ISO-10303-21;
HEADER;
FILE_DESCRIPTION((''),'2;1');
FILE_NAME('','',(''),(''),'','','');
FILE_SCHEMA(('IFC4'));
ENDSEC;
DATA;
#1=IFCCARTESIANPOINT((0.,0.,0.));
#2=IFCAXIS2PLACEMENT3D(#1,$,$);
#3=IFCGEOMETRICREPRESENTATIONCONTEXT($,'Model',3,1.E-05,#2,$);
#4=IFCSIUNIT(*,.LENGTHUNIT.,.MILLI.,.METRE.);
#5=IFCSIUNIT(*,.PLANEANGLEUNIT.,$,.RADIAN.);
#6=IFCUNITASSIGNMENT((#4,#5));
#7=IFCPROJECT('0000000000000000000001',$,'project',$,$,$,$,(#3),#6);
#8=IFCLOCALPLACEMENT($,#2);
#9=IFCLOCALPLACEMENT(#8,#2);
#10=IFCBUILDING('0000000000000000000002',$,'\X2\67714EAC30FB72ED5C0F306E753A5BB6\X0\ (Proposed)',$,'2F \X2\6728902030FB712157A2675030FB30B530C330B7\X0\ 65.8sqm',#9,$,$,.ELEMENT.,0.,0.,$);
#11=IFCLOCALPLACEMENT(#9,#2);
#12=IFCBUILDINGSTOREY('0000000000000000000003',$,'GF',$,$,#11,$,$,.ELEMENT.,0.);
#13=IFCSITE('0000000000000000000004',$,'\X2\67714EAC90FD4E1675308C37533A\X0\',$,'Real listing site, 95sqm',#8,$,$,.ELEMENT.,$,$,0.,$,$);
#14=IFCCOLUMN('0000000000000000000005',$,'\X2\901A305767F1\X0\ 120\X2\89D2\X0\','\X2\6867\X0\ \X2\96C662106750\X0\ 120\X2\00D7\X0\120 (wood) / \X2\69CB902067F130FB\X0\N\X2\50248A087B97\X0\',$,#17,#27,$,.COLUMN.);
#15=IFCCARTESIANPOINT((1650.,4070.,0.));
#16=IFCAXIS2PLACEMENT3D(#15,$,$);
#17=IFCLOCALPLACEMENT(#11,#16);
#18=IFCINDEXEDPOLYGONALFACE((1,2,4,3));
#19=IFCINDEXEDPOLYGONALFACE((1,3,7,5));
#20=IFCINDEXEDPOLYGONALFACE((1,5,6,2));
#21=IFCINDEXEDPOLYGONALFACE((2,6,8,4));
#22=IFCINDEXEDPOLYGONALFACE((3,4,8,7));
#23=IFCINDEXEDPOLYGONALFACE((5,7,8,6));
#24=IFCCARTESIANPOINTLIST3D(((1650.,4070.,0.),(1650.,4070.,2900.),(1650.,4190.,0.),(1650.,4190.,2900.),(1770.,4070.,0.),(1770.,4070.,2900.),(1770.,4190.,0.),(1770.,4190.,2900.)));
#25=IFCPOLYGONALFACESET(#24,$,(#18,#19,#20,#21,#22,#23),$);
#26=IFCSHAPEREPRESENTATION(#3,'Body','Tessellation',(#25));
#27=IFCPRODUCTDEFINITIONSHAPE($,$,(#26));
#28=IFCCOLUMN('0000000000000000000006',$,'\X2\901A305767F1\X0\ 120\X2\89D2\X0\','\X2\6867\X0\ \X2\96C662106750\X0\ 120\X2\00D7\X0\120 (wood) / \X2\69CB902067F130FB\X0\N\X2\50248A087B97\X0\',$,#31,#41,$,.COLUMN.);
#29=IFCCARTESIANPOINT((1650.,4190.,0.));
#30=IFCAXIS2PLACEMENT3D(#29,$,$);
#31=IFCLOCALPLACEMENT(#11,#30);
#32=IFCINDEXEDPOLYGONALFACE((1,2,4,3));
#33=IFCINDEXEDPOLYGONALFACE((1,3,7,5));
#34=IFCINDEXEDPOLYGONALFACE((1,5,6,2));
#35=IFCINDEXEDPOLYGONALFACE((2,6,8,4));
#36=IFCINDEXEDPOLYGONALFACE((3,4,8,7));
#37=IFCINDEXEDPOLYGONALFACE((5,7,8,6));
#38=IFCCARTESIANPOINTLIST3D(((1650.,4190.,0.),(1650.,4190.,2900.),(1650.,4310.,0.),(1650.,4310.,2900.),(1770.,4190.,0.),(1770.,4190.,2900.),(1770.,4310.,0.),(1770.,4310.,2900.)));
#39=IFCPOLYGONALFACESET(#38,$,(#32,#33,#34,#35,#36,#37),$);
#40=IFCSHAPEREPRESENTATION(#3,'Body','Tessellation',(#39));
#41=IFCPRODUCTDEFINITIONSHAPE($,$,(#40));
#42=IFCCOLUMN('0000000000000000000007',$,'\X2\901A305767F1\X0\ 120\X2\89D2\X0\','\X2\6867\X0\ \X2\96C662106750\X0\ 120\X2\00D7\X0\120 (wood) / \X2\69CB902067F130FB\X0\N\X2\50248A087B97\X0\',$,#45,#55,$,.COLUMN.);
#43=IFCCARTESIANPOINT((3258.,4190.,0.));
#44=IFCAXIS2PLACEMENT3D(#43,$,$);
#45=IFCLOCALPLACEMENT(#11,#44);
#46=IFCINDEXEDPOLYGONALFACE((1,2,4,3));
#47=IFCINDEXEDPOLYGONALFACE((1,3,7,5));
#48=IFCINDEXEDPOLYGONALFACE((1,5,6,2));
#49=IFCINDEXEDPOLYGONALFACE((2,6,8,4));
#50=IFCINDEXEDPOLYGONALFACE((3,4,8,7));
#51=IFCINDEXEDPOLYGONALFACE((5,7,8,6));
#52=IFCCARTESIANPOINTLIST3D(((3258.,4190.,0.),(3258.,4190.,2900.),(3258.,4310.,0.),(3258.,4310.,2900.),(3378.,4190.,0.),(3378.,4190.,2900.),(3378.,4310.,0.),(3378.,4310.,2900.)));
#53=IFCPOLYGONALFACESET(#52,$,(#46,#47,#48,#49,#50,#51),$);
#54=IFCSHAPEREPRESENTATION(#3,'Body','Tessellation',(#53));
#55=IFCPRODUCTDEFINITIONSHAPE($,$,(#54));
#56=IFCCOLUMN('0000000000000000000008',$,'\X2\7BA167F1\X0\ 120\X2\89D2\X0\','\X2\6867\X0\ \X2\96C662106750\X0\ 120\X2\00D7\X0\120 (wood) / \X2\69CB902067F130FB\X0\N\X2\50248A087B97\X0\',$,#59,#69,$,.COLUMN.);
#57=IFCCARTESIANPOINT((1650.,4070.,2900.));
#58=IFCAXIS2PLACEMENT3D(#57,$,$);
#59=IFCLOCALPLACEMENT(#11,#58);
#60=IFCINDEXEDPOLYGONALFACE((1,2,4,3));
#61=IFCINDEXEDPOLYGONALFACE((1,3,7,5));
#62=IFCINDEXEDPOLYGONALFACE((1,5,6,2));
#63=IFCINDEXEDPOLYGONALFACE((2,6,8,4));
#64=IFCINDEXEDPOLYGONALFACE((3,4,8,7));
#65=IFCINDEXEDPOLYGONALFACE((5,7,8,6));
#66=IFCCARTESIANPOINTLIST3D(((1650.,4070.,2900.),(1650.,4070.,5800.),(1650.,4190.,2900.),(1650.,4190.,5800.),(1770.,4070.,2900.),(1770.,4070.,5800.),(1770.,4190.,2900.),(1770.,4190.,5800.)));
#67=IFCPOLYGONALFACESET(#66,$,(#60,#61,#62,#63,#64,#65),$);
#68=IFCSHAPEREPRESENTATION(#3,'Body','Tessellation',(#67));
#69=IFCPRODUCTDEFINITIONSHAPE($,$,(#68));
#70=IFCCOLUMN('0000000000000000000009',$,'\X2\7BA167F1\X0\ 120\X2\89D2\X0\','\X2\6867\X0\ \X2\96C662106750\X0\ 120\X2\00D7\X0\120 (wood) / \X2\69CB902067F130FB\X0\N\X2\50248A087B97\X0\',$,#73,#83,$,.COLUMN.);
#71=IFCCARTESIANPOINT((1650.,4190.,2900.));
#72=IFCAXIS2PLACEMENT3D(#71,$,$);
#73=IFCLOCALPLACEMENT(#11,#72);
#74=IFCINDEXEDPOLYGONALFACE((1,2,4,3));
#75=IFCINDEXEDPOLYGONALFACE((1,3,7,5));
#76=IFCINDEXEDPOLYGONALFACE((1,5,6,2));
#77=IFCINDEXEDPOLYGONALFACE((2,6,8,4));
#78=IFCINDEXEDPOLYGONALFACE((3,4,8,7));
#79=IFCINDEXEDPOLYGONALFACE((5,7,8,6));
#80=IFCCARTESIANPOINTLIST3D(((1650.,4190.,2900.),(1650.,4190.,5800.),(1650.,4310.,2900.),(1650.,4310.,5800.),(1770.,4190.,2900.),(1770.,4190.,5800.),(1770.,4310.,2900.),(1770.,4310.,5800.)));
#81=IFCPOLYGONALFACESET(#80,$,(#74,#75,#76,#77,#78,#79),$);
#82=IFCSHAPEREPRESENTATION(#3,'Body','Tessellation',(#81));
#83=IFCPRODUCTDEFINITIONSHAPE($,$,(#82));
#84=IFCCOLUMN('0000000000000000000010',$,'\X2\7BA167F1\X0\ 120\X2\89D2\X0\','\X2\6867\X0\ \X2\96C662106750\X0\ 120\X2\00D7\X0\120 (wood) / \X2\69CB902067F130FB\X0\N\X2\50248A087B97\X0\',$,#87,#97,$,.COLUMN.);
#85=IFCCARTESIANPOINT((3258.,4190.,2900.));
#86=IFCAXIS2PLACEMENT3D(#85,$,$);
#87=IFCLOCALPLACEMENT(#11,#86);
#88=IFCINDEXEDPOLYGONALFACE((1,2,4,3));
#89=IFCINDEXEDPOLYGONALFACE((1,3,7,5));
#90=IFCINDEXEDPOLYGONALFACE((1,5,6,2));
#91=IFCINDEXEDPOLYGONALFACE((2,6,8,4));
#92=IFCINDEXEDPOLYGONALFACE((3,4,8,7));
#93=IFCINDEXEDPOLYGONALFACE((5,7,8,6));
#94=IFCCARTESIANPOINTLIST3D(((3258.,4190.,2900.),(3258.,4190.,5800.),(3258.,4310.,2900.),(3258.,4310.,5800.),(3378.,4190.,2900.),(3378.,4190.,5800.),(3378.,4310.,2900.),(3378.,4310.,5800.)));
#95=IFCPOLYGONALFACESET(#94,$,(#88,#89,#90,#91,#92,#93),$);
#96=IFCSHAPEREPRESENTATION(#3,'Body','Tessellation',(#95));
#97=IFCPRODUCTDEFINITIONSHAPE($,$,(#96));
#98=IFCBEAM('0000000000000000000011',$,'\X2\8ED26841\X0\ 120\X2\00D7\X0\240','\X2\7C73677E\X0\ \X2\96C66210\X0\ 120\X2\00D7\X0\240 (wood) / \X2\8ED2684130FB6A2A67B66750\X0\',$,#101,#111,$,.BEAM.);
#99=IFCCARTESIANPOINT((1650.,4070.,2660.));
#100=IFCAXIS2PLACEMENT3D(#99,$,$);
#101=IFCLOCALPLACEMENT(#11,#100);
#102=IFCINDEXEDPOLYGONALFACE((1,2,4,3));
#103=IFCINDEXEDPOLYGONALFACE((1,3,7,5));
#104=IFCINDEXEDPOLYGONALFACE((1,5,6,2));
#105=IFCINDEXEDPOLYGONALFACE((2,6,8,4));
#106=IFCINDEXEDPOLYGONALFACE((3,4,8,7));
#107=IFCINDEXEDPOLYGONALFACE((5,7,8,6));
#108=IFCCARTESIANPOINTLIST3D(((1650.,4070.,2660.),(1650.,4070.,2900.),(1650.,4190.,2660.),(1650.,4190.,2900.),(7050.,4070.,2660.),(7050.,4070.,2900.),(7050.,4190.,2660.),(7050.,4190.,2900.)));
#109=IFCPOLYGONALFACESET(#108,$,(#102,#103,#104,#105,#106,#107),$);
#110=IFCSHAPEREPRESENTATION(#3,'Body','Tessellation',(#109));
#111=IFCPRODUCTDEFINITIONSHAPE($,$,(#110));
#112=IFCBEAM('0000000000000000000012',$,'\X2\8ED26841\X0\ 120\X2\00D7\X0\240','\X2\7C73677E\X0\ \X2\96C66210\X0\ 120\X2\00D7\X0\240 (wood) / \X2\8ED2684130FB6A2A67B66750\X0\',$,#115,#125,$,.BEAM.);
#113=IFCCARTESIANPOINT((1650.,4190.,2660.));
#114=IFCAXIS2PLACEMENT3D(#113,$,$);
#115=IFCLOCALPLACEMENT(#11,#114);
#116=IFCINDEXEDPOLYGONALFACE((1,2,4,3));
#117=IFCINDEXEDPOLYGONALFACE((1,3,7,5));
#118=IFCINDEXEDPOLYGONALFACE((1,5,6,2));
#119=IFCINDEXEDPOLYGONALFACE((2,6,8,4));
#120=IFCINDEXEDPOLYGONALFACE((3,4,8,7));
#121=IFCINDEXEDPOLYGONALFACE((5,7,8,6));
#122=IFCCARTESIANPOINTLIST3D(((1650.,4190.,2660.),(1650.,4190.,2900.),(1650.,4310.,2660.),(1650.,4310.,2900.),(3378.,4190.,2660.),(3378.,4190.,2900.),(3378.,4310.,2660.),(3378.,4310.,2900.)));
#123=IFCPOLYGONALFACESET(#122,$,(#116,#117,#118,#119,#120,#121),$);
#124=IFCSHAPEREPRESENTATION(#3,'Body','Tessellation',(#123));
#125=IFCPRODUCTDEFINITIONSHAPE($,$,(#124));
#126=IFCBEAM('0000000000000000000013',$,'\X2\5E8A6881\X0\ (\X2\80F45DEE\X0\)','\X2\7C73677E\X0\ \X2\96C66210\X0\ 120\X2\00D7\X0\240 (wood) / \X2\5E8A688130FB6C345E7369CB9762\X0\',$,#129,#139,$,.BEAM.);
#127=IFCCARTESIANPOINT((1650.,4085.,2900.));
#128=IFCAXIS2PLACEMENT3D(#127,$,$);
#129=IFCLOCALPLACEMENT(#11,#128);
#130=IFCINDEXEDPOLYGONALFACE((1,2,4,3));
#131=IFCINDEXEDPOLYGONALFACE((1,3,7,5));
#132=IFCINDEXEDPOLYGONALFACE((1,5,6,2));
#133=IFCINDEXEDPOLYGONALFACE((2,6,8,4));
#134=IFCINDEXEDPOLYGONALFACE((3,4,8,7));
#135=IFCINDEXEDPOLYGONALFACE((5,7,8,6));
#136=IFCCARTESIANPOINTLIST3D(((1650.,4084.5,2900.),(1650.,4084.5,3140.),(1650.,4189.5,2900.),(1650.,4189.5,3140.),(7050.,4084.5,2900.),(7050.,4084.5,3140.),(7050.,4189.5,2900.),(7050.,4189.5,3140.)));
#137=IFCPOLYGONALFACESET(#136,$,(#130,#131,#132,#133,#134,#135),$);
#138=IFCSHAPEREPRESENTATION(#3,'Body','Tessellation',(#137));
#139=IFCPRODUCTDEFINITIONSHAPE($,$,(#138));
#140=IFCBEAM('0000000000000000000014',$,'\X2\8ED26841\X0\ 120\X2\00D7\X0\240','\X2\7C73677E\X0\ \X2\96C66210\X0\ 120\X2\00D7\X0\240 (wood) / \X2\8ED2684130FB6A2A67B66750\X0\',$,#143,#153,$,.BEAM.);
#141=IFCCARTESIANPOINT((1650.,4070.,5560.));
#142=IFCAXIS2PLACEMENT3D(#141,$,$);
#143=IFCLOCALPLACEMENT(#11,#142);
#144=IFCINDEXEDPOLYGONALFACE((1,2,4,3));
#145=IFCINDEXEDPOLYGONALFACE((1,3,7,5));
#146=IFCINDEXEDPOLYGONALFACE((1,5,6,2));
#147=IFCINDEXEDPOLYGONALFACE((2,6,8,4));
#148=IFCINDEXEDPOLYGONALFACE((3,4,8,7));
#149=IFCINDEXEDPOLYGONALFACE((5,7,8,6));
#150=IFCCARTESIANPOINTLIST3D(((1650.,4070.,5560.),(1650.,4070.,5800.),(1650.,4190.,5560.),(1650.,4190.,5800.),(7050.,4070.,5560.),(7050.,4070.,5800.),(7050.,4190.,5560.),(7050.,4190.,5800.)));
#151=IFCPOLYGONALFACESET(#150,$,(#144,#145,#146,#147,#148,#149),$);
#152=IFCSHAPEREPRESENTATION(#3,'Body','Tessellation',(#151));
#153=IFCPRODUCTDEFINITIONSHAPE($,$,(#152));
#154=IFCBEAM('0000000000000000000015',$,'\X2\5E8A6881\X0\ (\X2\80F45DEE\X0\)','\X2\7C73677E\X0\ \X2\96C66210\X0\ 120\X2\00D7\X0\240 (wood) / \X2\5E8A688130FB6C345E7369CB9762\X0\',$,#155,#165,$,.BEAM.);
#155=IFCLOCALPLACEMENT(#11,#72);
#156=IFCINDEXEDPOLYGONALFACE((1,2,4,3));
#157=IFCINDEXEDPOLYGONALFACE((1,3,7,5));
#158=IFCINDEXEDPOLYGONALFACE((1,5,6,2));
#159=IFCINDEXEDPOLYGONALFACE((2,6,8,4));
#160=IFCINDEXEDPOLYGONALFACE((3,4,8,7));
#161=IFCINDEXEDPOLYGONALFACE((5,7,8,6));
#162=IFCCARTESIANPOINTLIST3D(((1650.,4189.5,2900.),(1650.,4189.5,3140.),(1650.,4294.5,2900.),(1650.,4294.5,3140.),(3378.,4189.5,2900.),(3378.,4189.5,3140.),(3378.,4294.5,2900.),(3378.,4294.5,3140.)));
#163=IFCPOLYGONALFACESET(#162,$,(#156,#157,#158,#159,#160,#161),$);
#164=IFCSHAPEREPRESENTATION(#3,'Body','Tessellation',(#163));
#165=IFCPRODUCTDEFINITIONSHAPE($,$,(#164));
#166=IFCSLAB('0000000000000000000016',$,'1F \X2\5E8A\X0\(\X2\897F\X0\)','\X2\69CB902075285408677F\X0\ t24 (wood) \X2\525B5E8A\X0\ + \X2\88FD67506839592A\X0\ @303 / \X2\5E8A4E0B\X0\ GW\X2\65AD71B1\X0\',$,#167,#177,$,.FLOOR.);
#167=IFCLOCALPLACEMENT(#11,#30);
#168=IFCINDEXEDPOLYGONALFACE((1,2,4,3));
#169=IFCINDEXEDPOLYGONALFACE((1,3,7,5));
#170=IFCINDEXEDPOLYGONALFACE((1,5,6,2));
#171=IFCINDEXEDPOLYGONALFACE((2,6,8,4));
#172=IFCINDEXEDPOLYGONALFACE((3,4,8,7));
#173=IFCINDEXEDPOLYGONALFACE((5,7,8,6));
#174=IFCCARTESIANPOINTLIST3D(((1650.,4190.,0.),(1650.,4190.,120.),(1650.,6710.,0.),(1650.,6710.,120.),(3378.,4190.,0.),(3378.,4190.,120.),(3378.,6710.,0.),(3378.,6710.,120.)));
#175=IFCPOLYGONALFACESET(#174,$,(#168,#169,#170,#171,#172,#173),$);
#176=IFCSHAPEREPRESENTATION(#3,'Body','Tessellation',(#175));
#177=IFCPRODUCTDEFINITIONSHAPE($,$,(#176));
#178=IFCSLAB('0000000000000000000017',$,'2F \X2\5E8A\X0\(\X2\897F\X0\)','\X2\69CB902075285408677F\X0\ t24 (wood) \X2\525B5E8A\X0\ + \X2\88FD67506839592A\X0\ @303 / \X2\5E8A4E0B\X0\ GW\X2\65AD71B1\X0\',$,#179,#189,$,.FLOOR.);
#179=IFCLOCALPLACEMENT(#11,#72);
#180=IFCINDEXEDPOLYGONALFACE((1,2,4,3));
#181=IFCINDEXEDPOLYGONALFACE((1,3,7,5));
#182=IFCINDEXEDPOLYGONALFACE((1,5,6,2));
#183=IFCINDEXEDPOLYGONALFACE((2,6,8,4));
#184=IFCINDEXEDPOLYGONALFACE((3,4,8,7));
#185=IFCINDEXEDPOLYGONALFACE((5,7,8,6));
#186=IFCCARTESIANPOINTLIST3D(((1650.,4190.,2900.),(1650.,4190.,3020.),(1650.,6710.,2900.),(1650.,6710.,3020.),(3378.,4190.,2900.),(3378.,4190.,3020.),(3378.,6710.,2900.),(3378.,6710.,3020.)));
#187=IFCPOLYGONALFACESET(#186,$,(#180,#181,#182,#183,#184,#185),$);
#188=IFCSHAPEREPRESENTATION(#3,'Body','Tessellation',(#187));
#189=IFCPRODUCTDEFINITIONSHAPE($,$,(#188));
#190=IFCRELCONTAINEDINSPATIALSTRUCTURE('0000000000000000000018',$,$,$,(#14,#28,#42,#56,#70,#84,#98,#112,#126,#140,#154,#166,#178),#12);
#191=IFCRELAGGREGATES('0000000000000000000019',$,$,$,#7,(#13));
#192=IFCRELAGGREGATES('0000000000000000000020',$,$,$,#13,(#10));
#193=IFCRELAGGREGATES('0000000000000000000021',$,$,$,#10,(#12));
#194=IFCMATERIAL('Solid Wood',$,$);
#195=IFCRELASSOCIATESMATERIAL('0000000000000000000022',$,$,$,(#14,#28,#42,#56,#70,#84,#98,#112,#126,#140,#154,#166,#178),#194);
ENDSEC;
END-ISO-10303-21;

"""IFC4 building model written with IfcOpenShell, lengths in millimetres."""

from ifc_helpers import new_model, si_unit, frame, frame_2d, origin, place, context, project, spatial, rectangle, extrude, material, element, save


model = new_model("IFC4")

# Units and contexts
model_context = context("Model", 3, precision=1e-05, world=origin())
ifc_project = project(units=[si_unit("LENGTHUNIT", "METRE", prefix="MILLI"), si_unit("PLANEANGLEUNIT", "RADIAN")], contexts=[model_context])

# Site, building, storey
site_placement = place(None, origin())
site = spatial("IfcSite", under=ifc_project, at=site_placement, Name="東京都世田谷区", ObjectType="Real listing site, 95sqm", CompositionType="ELEMENT", RefElevation=0.0)
building_placement = place(site_placement, origin())
building = spatial("IfcBuilding", under=site, at=building_placement, Name="東京・狭小の町家 (Proposed)", ObjectType="2F 木造・無垢材・サッシ 65.8sqm", CompositionType="ELEMENT", ElevationOfRefHeight=0.0, ElevationOfTerrain=0.0)
storey_placement = place(building_placement, origin())
storey = spatial("IfcBuildingStorey", under=building, at=storey_placement, Name="GF", CompositionType="ELEMENT", Elevation=0.0)

# Columns
ifc_material_1 = material(Name="Solid Wood")
column_1_placement = place(storey_placement, frame((1650.0, 4070.0, 0.0)))
element("IfcColumn", 1, at=column_1_placement, inside=storey, material=ifc_material_1, Name="通し柱 120角", Description="桧 集成材 120×120 (wood) / 構造柱・N値計算", PredefinedType="COLUMN", context=model_context, shape_type="SweptSolid", body=[
    extrude(rectangle(XDim=120.0, YDim=120.0, at=frame_2d((60.0, 60.0))), frame((1650.0, 4070.0, 0.0)), (0.0, 0.0, 1.0), 2900.0),
])
column_2_placement = place(storey_placement, frame((1650.0, 4190.0, 0.0)))
element("IfcColumn", 2, at=column_2_placement, inside=storey, material=ifc_material_1, Name="通し柱 120角", Description="桧 集成材 120×120 (wood) / 構造柱・N値計算", PredefinedType="COLUMN", context=model_context, shape_type="SweptSolid", body=[
    extrude(rectangle(XDim=120.0, YDim=120.0, at=frame_2d((60.0, 60.0))), frame((1650.0, 4190.0, 0.0)), (0.0, 0.0, 1.0), 2900.0),
])
column_3_placement = place(storey_placement, frame((3258.0, 4190.0, 0.0)))
element("IfcColumn", 3, at=column_3_placement, inside=storey, material=ifc_material_1, Name="通し柱 120角", Description="桧 集成材 120×120 (wood) / 構造柱・N値計算", PredefinedType="COLUMN", context=model_context, shape_type="SweptSolid", body=[
    extrude(rectangle(XDim=120.0, YDim=120.0, at=frame_2d((60.0, 60.0))), frame((3258.0, 4190.0, 0.0)), (0.0, 0.0, 1.0), 2900.0),
])
column_4_placement = place(storey_placement, frame((1650.0, 4070.0, 2900.0)))
element("IfcColumn", 4, at=column_4_placement, inside=storey, material=ifc_material_1, Name="管柱 120角", Description="桧 集成材 120×120 (wood) / 構造柱・N値計算", PredefinedType="COLUMN", context=model_context, shape_type="SweptSolid", body=[
    extrude(rectangle(XDim=120.0, YDim=120.0, at=frame_2d((60.0, 60.0))), frame((1650.0, 4070.0, 2900.0)), (0.0, 0.0, 1.0), 2900.0),
])
column_5_placement = place(storey_placement, frame((1650.0, 4190.0, 2900.0)))
element("IfcColumn", 5, at=column_5_placement, inside=storey, material=ifc_material_1, Name="管柱 120角", Description="桧 集成材 120×120 (wood) / 構造柱・N値計算", PredefinedType="COLUMN", context=model_context, shape_type="SweptSolid", body=[
    extrude(rectangle(XDim=120.0, YDim=120.0, at=frame_2d((60.0, 60.0))), frame((1650.0, 4190.0, 2900.0)), (0.0, 0.0, 1.0), 2900.0),
])
column_6_placement = place(storey_placement, frame((3258.0, 4190.0, 2900.0)))
element("IfcColumn", 6, at=column_6_placement, inside=storey, material=ifc_material_1, Name="管柱 120角", Description="桧 集成材 120×120 (wood) / 構造柱・N値計算", PredefinedType="COLUMN", context=model_context, shape_type="SweptSolid", body=[
    extrude(rectangle(XDim=120.0, YDim=120.0, at=frame_2d((60.0, 60.0))), frame((3258.0, 4190.0, 2900.0)), (0.0, 0.0, 1.0), 2900.0),
])

# Beams
beam_1_placement = place(storey_placement, frame((1650.0, 4070.0, 2660.0)))
element("IfcBeam", 7, at=beam_1_placement, inside=storey, material=ifc_material_1, Name="軒桁 120×240", Description="米松 集成 120×240 (wood) / 軒桁・横架材", PredefinedType="BEAM", context=model_context, shape_type="SweptSolid", body=[
    extrude(rectangle(XDim=5400.0, YDim=120.0, at=frame_2d((2700.0, 60.0))), frame((1650.0, 4070.0, 2660.0)), (0.0, 0.0, 1.0), 240.0),
])
beam_2_placement = place(storey_placement, frame((1650.0, 4190.0, 2660.0)))
element("IfcBeam", 8, at=beam_2_placement, inside=storey, material=ifc_material_1, Name="軒桁 120×240", Description="米松 集成 120×240 (wood) / 軒桁・横架材", PredefinedType="BEAM", context=model_context, shape_type="SweptSolid", body=[
    extrude(rectangle(XDim=1728.0, YDim=120.0, at=frame_2d((864.0, 60.0))), frame((1650.0, 4190.0, 2660.0)), (0.0, 0.0, 1.0), 240.0),
])
beam_3_placement = place(storey_placement, frame((1650.0, 4085.0, 2900.0)))
element("IfcBeam", 9, at=beam_3_placement, inside=storey, material=ifc_material_1, Name="床梁 (胴差)", Description="米松 集成 120×240 (wood) / 床梁・水平構面", PredefinedType="BEAM", context=model_context, shape_type="SweptSolid", body=[
    extrude(rectangle(XDim=5400.0, YDim=105.0, at=frame_2d((2700.0, 52.0))), frame((1650.0, 4085.0, 2900.0)), (0.0, 0.0, 1.0), 240.0),
])
beam_4_placement = place(storey_placement, frame((1650.0, 4070.0, 5560.0)))
element("IfcBeam", 10, at=beam_4_placement, inside=storey, material=ifc_material_1, Name="軒桁 120×240", Description="米松 集成 120×240 (wood) / 軒桁・横架材", PredefinedType="BEAM", context=model_context, shape_type="SweptSolid", body=[
    extrude(rectangle(XDim=5400.0, YDim=120.0, at=frame_2d((2700.0, 60.0))), frame((1650.0, 4070.0, 5560.0)), (0.0, 0.0, 1.0), 240.0),
])
beam_5_placement = place(storey_placement, frame((1650.0, 4190.0, 2900.0)))
element("IfcBeam", 11, at=beam_5_placement, inside=storey, material=ifc_material_1, Name="床梁 (胴差)", Description="米松 集成 120×240 (wood) / 床梁・水平構面", PredefinedType="BEAM", context=model_context, shape_type="SweptSolid", body=[
    extrude(rectangle(XDim=1728.0, YDim=105.0, at=frame_2d((864.0, 52.0))), frame((1650.0, 4190.0, 2900.0)), (0.0, 0.0, 1.0), 240.0),
])

# Slabs
slab_1_placement = place(storey_placement, frame((1650.0, 4190.0, 0.0)))
element("IfcSlab", 12, at=slab_1_placement, inside=storey, material=ifc_material_1, Name="1F 床(西)", Description="構造用合板 t24 (wood) 剛床 + 製材根太 @303 / 床下 GW断熱", PredefinedType="FLOOR", context=model_context, shape_type="SweptSolid", body=[
    extrude(rectangle(XDim=1728.0, YDim=2520.0, at=frame_2d((864.0, 1260.0))), frame((1650.0, 4190.0, 0.0)), (0.0, 0.0, 1.0), 120.0),
])
slab_2_placement = place(storey_placement, frame((1650.0, 4190.0, 2900.0)))
element("IfcSlab", 13, at=slab_2_placement, inside=storey, material=ifc_material_1, Name="2F 床(西)", Description="構造用合板 t24 (wood) 剛床 + 製材根太 @303 / 床下 GW断熱", PredefinedType="FLOOR", context=model_context, shape_type="SweptSolid", body=[
    extrude(rectangle(XDim=1728.0, YDim=2520.0, at=frame_2d((864.0, 1260.0))), frame((1650.0, 4190.0, 2900.0)), (0.0, 0.0, 1.0), 120.0),
])

save(model, "model.ifc")
